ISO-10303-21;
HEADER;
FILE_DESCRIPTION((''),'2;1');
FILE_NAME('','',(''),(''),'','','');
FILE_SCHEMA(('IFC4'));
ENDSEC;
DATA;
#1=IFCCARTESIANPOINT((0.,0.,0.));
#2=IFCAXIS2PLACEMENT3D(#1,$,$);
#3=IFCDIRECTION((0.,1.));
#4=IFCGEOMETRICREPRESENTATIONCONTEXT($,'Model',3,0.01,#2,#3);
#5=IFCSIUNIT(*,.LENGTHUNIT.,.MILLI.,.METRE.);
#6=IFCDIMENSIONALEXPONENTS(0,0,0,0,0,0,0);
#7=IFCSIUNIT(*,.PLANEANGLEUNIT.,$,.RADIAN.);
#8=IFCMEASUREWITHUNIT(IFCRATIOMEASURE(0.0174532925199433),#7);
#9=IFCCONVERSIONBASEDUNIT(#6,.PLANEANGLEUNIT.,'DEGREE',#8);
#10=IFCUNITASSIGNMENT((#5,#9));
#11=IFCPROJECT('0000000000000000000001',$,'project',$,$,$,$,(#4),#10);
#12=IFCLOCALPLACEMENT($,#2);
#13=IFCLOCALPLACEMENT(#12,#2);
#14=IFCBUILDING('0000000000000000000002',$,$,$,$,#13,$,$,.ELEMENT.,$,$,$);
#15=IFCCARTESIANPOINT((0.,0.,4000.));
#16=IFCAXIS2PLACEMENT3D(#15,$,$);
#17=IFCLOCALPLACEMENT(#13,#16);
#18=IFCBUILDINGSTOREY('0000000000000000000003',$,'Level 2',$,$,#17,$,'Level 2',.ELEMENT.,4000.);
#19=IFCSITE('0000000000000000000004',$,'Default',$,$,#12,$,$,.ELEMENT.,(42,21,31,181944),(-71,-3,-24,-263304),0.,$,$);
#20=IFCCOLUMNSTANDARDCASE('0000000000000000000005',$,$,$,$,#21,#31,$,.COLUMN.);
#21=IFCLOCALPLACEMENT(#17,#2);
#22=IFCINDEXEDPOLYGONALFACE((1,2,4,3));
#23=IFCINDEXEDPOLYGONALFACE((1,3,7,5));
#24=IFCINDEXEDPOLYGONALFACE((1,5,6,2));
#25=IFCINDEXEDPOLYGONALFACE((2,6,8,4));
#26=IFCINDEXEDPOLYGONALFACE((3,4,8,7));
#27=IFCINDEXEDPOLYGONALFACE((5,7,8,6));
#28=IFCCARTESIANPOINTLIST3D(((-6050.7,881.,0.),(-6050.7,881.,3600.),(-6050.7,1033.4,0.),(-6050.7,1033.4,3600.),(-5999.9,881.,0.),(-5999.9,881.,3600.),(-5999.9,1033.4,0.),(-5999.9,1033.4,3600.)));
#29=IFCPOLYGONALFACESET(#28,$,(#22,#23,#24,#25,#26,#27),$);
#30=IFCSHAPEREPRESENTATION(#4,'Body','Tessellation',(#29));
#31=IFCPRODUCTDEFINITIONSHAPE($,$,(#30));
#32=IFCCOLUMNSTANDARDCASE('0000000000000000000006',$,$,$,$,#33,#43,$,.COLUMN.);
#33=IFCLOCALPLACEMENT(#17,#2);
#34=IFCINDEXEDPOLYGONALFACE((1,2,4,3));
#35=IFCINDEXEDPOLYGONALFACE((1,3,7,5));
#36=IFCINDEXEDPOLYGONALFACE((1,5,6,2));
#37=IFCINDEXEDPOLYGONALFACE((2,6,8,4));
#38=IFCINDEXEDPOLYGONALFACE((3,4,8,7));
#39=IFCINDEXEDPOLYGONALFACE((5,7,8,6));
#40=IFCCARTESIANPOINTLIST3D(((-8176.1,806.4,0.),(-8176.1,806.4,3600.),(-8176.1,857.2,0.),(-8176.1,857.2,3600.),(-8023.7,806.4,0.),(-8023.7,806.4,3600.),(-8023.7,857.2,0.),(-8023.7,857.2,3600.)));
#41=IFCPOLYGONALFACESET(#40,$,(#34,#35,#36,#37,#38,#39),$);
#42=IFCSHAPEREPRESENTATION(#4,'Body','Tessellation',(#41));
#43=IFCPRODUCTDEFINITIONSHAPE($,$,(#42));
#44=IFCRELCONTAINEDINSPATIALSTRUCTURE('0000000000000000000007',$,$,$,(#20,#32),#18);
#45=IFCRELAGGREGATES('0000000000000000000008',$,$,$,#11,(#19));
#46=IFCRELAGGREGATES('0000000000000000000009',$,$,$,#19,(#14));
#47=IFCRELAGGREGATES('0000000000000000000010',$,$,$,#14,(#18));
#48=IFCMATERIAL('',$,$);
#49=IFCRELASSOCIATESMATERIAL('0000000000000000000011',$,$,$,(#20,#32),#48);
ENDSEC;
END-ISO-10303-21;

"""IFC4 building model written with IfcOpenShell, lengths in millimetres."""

from ifc_helpers import new_model, entity, si_unit, converted_unit, direction, frame, origin, place, context, project, spatial, rectangle, extrude, material, element, save


model = new_model("IFC4")

# Units and contexts
model_context = context("Model", 3, precision=0.01, world=origin(), true_north=direction((0.0, 1.0)))
ifc_project = project(units=[si_unit("LENGTHUNIT", "METRE", prefix="MILLI"), converted_unit("PLANEANGLEUNIT", "DEGREE", entity("IfcRatioMeasure", 0.0174532925199433), si_unit("PLANEANGLEUNIT", "RADIAN"), dimensions=[0, 0, 0, 0, 0, 0, 0])], contexts=[model_context])

# Site, building, storey
site_placement = place(None, origin())
site = spatial("IfcSite", under=ifc_project, at=site_placement, Name="Default", CompositionType="ELEMENT", RefLatitude=(42, 21, 31, 181944), RefLongitude=(-71, -3, -24, -263304), RefElevation=0.0)
building_placement = place(site_placement, origin())
building = spatial("IfcBuilding", under=site, at=building_placement, CompositionType="ELEMENT")
storey_placement = place(building_placement, frame((0.0, 0.0, 4000.0)))
storey = spatial("IfcBuildingStorey", under=building, at=storey_placement, Name="Level 2", LongName="Level 2", CompositionType="ELEMENT", Elevation=4000.0)

# Columns
ifc_material_1 = material(Name="")
placement_1 = place(storey_placement, frame((-5999.9, 957.2, 0.0), z_axis=(0.0, 0.0, 1.0), x_axis=(-1.0, 0.0, 0.0)))
column_1_placement = place(placement_1, frame((25.4, 0.0, 0.0), z_axis=(0.0, 0.0, 1.0), x_axis=(1.0, 0.0, 0.0)))
element("IfcColumnStandardCase", 1, at=column_1_placement, inside=storey, material=ifc_material_1, PredefinedType="COLUMN", context=model_context, shape_type="SweptSolid", body=[
    extrude(rectangle(XDim=50.8, YDim=152.4), origin(), (0.0, 0.0, 1.0), 3600.0),
])
placement_2 = place(storey_placement, frame((-8099.9, 857.2, 0.0), z_axis=(0.0, 0.0, 1.0), x_axis=(0.0, -1.0, 0.0)))
for number, where, z_axis, x_axis in (
    (2, (25.4, 0.0, 0.0), (0.0, 0.0, 1.0), (1.0, 0.0, 0.0)),
):
    element("IfcColumnStandardCase", number, at=place(placement_2, frame(where, z_axis=z_axis, x_axis=x_axis)), inside=storey, material=ifc_material_1, PredefinedType="COLUMN", context=model_context, shape_type="SweptSolid", body=[
        extrude(rectangle(XDim=50.8, YDim=152.4), origin(), (0.0, 0.0, 1.0), 3600.0),
    ])

save(model, "model.ifc")
